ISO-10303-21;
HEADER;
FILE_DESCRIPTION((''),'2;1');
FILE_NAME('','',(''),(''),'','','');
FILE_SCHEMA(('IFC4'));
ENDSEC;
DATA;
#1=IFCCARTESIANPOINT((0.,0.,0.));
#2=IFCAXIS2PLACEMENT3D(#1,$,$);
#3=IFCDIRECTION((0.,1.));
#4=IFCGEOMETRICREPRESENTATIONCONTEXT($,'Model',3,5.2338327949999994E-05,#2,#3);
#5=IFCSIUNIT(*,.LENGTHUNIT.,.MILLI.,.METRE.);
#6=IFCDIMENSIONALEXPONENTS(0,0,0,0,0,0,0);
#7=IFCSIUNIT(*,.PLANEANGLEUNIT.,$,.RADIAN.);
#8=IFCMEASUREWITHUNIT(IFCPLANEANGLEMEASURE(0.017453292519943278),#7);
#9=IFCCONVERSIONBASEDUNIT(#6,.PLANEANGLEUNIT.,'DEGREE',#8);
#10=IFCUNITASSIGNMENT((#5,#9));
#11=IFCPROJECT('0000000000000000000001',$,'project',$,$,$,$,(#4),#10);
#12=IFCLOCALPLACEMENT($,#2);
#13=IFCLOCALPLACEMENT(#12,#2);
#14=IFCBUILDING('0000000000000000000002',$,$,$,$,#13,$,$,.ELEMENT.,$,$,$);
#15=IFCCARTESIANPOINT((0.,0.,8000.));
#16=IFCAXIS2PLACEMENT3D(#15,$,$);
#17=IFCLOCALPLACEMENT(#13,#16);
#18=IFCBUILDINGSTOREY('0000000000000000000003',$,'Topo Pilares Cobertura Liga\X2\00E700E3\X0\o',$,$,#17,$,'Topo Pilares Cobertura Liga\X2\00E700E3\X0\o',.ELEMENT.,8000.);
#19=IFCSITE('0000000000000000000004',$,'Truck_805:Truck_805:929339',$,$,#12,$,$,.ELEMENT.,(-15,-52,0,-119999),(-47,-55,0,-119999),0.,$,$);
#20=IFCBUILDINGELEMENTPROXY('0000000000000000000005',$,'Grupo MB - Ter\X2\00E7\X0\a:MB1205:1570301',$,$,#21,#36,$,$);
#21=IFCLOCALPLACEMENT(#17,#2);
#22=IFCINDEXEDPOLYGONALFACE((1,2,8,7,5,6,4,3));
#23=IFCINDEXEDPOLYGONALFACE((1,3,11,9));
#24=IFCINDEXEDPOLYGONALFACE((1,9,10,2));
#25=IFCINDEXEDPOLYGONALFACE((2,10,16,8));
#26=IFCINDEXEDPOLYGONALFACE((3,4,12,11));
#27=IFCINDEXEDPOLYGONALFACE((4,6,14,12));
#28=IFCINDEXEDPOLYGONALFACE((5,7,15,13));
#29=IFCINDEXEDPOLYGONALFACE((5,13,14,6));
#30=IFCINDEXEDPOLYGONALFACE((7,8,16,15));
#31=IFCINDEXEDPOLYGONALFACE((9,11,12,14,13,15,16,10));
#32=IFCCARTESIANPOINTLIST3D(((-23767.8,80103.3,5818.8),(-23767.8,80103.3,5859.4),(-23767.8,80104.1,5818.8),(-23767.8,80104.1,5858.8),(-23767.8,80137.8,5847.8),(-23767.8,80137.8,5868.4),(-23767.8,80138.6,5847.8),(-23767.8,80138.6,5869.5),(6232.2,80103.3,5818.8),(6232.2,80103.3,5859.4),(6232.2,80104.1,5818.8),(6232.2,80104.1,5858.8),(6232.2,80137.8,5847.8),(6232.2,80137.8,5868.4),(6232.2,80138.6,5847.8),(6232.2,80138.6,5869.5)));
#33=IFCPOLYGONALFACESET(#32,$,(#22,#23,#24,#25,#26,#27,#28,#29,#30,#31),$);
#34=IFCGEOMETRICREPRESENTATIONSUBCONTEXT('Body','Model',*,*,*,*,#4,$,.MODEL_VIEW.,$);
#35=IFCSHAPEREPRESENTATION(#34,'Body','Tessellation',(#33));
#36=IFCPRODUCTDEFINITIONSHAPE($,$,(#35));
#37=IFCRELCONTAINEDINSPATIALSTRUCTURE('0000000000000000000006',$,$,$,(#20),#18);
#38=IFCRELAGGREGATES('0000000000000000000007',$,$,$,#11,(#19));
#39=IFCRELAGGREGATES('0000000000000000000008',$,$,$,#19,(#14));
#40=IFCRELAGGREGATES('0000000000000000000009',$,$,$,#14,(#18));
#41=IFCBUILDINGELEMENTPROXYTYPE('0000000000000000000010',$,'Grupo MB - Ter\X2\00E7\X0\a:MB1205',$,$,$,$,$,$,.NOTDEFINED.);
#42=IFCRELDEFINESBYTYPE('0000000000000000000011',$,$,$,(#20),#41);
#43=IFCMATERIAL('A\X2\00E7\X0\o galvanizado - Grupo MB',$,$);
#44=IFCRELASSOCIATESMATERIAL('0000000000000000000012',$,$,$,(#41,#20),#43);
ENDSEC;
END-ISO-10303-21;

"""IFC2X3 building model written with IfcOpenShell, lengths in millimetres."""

from ifc_helpers import new_model, entity, si_unit, converted_unit, direction, frame, origin, place, context, subcontext, project, spatial, polyline, outline, extrude, source, transform, mapped, material, type_object, type_shapes, element, save


model = new_model("IFC2X3")

# Units and contexts
model_context = context("Model", 3, precision=5.2338327949999994e-05, world=origin(), true_north=direction((0.0, 1.0)))
body_context = subcontext(model_context, "Body", "Model", "MODEL_VIEW")
ifc_project = project(units=[si_unit("LENGTHUNIT", "METRE", prefix="MILLI"), converted_unit("PLANEANGLEUNIT", "DEGREE", entity("IfcPlaneAngleMeasure", 0.017453292519943278), si_unit("PLANEANGLEUNIT", "RADIAN"), dimensions=[0, 0, 0, 0, 0, 0, 0])], contexts=[model_context])

# Site, building, storey
site_placement = place(None, origin())
site = spatial("IfcSite", under=ifc_project, at=site_placement, Name="Truck_805:Truck_805:929339", CompositionType="ELEMENT", RefLatitude=(-15, -52, 0, -119999), RefLongitude=(-47, -55, 0, -119999), RefElevation=0.0)
building_placement = place(site_placement, origin())
building = spatial("IfcBuilding", under=site, at=building_placement, CompositionType="ELEMENT")
storey_placement = place(building_placement, frame((0.0, 0.0, 8000.0)))
storey = spatial("IfcBuildingStorey", under=building, at=storey_placement, Name="Topo Pilares Cobertura Ligação", LongName="Topo Pilares Cobertura Ligação", CompositionType="ELEMENT", Elevation=8000.0)

# Building element proxy
ifc_material_1 = material(Name="Aço galvanizado - Grupo MB")
building_element_proxy_type_1 = type_object("IfcBuildingElementProxyType", Name="Grupo MB - Terça:MB1205", PredefinedType="NOTDEFINED", material=ifc_material_1)
shared_shape_1 = source(origin(), body_context, "Body", "SweptSolid", [
    extrude(outline(polyline([(-13.5, -14.4), (-24.4, 24.1), (-25.2, 23.9), (-14.1, -15.2), (22.7, -15.2), (16.8, 5.7), (16.0, 5.4), (21.6, -14.4), (-13.5, -14.4)])), frame((0.0, 16.9, -10.1), z_axis=(-1.0, 0.0, 0.0), x_axis=(0.0, 0.961789, 0.273791)), (0.0, 0.0, -1.0), 30000.0),
])
type_shapes(building_element_proxy_type_1, [shared_shape_1])
proxy_1_placement = place(storey_placement, frame((-23767.8, 80104.1, 5858.8)))
element("IfcBuildingElementProxy", 1, at=proxy_1_placement, inside=storey, type_object=building_element_proxy_type_1, material=ifc_material_1, Name="Grupo MB - Terça:MB1205:1570301", context=body_context, shape_type="MappedRepresentation", body=[
    mapped(shared_shape_1, transform((0.0, 0.0, 0.0), scale=1.0)),
])

save(model, "model.ifc")
